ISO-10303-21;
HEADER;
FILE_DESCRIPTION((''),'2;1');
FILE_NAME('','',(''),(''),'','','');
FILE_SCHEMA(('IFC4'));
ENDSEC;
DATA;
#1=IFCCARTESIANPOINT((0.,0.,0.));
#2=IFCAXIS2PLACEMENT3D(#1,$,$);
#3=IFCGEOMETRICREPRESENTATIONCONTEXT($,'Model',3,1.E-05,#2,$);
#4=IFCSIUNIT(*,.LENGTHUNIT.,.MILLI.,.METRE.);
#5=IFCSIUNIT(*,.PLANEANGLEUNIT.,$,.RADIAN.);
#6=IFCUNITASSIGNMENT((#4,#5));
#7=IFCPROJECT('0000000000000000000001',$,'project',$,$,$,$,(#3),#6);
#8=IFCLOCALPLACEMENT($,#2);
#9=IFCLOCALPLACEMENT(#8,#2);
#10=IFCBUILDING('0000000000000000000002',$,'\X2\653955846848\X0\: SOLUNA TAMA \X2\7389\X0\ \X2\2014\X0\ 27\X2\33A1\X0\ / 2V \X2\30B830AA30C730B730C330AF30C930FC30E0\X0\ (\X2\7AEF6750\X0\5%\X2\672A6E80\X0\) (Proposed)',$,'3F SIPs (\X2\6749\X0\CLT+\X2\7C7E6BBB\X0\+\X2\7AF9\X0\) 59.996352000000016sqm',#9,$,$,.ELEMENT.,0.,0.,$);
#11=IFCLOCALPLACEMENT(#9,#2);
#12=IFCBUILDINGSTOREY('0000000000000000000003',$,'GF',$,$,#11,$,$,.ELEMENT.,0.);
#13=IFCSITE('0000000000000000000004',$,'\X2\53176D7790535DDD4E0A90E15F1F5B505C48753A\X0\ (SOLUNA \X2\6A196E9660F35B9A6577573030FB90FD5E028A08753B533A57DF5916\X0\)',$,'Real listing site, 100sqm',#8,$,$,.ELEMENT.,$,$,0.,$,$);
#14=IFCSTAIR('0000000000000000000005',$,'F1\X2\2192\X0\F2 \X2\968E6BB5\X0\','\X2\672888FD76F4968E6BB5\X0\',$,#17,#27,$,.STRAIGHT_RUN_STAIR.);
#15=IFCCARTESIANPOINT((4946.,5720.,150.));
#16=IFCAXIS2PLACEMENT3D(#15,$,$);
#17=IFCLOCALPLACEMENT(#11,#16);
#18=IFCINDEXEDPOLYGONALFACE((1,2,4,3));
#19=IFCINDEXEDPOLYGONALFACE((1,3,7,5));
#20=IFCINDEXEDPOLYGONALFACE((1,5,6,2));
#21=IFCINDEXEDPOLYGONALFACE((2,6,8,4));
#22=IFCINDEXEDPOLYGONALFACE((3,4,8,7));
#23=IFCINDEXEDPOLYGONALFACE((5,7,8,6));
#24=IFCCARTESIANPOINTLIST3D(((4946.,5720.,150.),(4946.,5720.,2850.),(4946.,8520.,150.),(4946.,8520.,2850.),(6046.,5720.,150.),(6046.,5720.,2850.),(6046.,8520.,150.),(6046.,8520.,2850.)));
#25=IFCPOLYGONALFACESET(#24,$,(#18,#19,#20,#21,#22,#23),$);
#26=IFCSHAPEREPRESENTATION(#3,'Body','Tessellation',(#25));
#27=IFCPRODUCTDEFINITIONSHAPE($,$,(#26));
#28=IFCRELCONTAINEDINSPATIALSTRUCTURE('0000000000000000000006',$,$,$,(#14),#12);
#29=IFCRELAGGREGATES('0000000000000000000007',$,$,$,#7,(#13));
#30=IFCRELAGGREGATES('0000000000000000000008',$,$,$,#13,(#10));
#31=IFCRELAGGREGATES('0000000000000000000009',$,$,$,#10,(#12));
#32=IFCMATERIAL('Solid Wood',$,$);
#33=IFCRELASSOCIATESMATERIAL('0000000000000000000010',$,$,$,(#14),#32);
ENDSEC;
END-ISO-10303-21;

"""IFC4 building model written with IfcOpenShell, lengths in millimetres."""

from ifc_helpers import new_model, si_unit, frame, frame_2d, origin, place, context, project, spatial, rectangle, extrude, material, element, save


model = new_model("IFC4")

# Units and contexts
model_context = context("Model", 3, precision=1e-05, world=origin())
ifc_project = project(units=[si_unit("LENGTHUNIT", "METRE", prefix="MILLI"), si_unit("PLANEANGLEUNIT", "RADIAN")], contexts=[model_context])

# Site, building, storey
site_placement = place(None, origin())
site = spatial("IfcSite", under=ifc_project, at=site_placement, Name="北海道川上郡弟子屈町 (SOLUNA 標準想定敷地・都市計画区域外)", ObjectType="Real listing site, 100sqm", CompositionType="ELEMENT", RefElevation=0.0)
building_placement = place(site_placement, origin())
building = spatial("IfcBuilding", under=site, at=building_placement, Name="改善案: SOLUNA TAMA 玉 — 27㎡ / 2V ジオデシックドーム (端材5%未満) (Proposed)", ObjectType="3F SIPs (杉CLT+籾殻+竹) 59.996352000000016sqm", CompositionType="ELEMENT", ElevationOfRefHeight=0.0, ElevationOfTerrain=0.0)
storey_placement = place(building_placement, origin())
storey = spatial("IfcBuildingStorey", under=building, at=storey_placement, Name="GF", CompositionType="ELEMENT", Elevation=0.0)

# Shared definitions
ifc_material_1 = material(Name="Solid Wood")

# Stair
stair_placement = place(storey_placement, frame((4946.0, 5720.0, 150.0)))
element("IfcStair", 1, at=stair_placement, inside=storey, material=ifc_material_1, Name="F1→F2 階段", Description="木製直階段", PredefinedType="STRAIGHT_RUN_STAIR", context=model_context, shape_type="SweptSolid", body=[
    extrude(rectangle(XDim=1100.0, YDim=2800.0, at=frame_2d((550.0, 1400.0))), frame((4946.0, 5720.0, 150.0)), (0.0, 0.0, 1.0), 2700.0),
])

save(model, "model.ifc")
